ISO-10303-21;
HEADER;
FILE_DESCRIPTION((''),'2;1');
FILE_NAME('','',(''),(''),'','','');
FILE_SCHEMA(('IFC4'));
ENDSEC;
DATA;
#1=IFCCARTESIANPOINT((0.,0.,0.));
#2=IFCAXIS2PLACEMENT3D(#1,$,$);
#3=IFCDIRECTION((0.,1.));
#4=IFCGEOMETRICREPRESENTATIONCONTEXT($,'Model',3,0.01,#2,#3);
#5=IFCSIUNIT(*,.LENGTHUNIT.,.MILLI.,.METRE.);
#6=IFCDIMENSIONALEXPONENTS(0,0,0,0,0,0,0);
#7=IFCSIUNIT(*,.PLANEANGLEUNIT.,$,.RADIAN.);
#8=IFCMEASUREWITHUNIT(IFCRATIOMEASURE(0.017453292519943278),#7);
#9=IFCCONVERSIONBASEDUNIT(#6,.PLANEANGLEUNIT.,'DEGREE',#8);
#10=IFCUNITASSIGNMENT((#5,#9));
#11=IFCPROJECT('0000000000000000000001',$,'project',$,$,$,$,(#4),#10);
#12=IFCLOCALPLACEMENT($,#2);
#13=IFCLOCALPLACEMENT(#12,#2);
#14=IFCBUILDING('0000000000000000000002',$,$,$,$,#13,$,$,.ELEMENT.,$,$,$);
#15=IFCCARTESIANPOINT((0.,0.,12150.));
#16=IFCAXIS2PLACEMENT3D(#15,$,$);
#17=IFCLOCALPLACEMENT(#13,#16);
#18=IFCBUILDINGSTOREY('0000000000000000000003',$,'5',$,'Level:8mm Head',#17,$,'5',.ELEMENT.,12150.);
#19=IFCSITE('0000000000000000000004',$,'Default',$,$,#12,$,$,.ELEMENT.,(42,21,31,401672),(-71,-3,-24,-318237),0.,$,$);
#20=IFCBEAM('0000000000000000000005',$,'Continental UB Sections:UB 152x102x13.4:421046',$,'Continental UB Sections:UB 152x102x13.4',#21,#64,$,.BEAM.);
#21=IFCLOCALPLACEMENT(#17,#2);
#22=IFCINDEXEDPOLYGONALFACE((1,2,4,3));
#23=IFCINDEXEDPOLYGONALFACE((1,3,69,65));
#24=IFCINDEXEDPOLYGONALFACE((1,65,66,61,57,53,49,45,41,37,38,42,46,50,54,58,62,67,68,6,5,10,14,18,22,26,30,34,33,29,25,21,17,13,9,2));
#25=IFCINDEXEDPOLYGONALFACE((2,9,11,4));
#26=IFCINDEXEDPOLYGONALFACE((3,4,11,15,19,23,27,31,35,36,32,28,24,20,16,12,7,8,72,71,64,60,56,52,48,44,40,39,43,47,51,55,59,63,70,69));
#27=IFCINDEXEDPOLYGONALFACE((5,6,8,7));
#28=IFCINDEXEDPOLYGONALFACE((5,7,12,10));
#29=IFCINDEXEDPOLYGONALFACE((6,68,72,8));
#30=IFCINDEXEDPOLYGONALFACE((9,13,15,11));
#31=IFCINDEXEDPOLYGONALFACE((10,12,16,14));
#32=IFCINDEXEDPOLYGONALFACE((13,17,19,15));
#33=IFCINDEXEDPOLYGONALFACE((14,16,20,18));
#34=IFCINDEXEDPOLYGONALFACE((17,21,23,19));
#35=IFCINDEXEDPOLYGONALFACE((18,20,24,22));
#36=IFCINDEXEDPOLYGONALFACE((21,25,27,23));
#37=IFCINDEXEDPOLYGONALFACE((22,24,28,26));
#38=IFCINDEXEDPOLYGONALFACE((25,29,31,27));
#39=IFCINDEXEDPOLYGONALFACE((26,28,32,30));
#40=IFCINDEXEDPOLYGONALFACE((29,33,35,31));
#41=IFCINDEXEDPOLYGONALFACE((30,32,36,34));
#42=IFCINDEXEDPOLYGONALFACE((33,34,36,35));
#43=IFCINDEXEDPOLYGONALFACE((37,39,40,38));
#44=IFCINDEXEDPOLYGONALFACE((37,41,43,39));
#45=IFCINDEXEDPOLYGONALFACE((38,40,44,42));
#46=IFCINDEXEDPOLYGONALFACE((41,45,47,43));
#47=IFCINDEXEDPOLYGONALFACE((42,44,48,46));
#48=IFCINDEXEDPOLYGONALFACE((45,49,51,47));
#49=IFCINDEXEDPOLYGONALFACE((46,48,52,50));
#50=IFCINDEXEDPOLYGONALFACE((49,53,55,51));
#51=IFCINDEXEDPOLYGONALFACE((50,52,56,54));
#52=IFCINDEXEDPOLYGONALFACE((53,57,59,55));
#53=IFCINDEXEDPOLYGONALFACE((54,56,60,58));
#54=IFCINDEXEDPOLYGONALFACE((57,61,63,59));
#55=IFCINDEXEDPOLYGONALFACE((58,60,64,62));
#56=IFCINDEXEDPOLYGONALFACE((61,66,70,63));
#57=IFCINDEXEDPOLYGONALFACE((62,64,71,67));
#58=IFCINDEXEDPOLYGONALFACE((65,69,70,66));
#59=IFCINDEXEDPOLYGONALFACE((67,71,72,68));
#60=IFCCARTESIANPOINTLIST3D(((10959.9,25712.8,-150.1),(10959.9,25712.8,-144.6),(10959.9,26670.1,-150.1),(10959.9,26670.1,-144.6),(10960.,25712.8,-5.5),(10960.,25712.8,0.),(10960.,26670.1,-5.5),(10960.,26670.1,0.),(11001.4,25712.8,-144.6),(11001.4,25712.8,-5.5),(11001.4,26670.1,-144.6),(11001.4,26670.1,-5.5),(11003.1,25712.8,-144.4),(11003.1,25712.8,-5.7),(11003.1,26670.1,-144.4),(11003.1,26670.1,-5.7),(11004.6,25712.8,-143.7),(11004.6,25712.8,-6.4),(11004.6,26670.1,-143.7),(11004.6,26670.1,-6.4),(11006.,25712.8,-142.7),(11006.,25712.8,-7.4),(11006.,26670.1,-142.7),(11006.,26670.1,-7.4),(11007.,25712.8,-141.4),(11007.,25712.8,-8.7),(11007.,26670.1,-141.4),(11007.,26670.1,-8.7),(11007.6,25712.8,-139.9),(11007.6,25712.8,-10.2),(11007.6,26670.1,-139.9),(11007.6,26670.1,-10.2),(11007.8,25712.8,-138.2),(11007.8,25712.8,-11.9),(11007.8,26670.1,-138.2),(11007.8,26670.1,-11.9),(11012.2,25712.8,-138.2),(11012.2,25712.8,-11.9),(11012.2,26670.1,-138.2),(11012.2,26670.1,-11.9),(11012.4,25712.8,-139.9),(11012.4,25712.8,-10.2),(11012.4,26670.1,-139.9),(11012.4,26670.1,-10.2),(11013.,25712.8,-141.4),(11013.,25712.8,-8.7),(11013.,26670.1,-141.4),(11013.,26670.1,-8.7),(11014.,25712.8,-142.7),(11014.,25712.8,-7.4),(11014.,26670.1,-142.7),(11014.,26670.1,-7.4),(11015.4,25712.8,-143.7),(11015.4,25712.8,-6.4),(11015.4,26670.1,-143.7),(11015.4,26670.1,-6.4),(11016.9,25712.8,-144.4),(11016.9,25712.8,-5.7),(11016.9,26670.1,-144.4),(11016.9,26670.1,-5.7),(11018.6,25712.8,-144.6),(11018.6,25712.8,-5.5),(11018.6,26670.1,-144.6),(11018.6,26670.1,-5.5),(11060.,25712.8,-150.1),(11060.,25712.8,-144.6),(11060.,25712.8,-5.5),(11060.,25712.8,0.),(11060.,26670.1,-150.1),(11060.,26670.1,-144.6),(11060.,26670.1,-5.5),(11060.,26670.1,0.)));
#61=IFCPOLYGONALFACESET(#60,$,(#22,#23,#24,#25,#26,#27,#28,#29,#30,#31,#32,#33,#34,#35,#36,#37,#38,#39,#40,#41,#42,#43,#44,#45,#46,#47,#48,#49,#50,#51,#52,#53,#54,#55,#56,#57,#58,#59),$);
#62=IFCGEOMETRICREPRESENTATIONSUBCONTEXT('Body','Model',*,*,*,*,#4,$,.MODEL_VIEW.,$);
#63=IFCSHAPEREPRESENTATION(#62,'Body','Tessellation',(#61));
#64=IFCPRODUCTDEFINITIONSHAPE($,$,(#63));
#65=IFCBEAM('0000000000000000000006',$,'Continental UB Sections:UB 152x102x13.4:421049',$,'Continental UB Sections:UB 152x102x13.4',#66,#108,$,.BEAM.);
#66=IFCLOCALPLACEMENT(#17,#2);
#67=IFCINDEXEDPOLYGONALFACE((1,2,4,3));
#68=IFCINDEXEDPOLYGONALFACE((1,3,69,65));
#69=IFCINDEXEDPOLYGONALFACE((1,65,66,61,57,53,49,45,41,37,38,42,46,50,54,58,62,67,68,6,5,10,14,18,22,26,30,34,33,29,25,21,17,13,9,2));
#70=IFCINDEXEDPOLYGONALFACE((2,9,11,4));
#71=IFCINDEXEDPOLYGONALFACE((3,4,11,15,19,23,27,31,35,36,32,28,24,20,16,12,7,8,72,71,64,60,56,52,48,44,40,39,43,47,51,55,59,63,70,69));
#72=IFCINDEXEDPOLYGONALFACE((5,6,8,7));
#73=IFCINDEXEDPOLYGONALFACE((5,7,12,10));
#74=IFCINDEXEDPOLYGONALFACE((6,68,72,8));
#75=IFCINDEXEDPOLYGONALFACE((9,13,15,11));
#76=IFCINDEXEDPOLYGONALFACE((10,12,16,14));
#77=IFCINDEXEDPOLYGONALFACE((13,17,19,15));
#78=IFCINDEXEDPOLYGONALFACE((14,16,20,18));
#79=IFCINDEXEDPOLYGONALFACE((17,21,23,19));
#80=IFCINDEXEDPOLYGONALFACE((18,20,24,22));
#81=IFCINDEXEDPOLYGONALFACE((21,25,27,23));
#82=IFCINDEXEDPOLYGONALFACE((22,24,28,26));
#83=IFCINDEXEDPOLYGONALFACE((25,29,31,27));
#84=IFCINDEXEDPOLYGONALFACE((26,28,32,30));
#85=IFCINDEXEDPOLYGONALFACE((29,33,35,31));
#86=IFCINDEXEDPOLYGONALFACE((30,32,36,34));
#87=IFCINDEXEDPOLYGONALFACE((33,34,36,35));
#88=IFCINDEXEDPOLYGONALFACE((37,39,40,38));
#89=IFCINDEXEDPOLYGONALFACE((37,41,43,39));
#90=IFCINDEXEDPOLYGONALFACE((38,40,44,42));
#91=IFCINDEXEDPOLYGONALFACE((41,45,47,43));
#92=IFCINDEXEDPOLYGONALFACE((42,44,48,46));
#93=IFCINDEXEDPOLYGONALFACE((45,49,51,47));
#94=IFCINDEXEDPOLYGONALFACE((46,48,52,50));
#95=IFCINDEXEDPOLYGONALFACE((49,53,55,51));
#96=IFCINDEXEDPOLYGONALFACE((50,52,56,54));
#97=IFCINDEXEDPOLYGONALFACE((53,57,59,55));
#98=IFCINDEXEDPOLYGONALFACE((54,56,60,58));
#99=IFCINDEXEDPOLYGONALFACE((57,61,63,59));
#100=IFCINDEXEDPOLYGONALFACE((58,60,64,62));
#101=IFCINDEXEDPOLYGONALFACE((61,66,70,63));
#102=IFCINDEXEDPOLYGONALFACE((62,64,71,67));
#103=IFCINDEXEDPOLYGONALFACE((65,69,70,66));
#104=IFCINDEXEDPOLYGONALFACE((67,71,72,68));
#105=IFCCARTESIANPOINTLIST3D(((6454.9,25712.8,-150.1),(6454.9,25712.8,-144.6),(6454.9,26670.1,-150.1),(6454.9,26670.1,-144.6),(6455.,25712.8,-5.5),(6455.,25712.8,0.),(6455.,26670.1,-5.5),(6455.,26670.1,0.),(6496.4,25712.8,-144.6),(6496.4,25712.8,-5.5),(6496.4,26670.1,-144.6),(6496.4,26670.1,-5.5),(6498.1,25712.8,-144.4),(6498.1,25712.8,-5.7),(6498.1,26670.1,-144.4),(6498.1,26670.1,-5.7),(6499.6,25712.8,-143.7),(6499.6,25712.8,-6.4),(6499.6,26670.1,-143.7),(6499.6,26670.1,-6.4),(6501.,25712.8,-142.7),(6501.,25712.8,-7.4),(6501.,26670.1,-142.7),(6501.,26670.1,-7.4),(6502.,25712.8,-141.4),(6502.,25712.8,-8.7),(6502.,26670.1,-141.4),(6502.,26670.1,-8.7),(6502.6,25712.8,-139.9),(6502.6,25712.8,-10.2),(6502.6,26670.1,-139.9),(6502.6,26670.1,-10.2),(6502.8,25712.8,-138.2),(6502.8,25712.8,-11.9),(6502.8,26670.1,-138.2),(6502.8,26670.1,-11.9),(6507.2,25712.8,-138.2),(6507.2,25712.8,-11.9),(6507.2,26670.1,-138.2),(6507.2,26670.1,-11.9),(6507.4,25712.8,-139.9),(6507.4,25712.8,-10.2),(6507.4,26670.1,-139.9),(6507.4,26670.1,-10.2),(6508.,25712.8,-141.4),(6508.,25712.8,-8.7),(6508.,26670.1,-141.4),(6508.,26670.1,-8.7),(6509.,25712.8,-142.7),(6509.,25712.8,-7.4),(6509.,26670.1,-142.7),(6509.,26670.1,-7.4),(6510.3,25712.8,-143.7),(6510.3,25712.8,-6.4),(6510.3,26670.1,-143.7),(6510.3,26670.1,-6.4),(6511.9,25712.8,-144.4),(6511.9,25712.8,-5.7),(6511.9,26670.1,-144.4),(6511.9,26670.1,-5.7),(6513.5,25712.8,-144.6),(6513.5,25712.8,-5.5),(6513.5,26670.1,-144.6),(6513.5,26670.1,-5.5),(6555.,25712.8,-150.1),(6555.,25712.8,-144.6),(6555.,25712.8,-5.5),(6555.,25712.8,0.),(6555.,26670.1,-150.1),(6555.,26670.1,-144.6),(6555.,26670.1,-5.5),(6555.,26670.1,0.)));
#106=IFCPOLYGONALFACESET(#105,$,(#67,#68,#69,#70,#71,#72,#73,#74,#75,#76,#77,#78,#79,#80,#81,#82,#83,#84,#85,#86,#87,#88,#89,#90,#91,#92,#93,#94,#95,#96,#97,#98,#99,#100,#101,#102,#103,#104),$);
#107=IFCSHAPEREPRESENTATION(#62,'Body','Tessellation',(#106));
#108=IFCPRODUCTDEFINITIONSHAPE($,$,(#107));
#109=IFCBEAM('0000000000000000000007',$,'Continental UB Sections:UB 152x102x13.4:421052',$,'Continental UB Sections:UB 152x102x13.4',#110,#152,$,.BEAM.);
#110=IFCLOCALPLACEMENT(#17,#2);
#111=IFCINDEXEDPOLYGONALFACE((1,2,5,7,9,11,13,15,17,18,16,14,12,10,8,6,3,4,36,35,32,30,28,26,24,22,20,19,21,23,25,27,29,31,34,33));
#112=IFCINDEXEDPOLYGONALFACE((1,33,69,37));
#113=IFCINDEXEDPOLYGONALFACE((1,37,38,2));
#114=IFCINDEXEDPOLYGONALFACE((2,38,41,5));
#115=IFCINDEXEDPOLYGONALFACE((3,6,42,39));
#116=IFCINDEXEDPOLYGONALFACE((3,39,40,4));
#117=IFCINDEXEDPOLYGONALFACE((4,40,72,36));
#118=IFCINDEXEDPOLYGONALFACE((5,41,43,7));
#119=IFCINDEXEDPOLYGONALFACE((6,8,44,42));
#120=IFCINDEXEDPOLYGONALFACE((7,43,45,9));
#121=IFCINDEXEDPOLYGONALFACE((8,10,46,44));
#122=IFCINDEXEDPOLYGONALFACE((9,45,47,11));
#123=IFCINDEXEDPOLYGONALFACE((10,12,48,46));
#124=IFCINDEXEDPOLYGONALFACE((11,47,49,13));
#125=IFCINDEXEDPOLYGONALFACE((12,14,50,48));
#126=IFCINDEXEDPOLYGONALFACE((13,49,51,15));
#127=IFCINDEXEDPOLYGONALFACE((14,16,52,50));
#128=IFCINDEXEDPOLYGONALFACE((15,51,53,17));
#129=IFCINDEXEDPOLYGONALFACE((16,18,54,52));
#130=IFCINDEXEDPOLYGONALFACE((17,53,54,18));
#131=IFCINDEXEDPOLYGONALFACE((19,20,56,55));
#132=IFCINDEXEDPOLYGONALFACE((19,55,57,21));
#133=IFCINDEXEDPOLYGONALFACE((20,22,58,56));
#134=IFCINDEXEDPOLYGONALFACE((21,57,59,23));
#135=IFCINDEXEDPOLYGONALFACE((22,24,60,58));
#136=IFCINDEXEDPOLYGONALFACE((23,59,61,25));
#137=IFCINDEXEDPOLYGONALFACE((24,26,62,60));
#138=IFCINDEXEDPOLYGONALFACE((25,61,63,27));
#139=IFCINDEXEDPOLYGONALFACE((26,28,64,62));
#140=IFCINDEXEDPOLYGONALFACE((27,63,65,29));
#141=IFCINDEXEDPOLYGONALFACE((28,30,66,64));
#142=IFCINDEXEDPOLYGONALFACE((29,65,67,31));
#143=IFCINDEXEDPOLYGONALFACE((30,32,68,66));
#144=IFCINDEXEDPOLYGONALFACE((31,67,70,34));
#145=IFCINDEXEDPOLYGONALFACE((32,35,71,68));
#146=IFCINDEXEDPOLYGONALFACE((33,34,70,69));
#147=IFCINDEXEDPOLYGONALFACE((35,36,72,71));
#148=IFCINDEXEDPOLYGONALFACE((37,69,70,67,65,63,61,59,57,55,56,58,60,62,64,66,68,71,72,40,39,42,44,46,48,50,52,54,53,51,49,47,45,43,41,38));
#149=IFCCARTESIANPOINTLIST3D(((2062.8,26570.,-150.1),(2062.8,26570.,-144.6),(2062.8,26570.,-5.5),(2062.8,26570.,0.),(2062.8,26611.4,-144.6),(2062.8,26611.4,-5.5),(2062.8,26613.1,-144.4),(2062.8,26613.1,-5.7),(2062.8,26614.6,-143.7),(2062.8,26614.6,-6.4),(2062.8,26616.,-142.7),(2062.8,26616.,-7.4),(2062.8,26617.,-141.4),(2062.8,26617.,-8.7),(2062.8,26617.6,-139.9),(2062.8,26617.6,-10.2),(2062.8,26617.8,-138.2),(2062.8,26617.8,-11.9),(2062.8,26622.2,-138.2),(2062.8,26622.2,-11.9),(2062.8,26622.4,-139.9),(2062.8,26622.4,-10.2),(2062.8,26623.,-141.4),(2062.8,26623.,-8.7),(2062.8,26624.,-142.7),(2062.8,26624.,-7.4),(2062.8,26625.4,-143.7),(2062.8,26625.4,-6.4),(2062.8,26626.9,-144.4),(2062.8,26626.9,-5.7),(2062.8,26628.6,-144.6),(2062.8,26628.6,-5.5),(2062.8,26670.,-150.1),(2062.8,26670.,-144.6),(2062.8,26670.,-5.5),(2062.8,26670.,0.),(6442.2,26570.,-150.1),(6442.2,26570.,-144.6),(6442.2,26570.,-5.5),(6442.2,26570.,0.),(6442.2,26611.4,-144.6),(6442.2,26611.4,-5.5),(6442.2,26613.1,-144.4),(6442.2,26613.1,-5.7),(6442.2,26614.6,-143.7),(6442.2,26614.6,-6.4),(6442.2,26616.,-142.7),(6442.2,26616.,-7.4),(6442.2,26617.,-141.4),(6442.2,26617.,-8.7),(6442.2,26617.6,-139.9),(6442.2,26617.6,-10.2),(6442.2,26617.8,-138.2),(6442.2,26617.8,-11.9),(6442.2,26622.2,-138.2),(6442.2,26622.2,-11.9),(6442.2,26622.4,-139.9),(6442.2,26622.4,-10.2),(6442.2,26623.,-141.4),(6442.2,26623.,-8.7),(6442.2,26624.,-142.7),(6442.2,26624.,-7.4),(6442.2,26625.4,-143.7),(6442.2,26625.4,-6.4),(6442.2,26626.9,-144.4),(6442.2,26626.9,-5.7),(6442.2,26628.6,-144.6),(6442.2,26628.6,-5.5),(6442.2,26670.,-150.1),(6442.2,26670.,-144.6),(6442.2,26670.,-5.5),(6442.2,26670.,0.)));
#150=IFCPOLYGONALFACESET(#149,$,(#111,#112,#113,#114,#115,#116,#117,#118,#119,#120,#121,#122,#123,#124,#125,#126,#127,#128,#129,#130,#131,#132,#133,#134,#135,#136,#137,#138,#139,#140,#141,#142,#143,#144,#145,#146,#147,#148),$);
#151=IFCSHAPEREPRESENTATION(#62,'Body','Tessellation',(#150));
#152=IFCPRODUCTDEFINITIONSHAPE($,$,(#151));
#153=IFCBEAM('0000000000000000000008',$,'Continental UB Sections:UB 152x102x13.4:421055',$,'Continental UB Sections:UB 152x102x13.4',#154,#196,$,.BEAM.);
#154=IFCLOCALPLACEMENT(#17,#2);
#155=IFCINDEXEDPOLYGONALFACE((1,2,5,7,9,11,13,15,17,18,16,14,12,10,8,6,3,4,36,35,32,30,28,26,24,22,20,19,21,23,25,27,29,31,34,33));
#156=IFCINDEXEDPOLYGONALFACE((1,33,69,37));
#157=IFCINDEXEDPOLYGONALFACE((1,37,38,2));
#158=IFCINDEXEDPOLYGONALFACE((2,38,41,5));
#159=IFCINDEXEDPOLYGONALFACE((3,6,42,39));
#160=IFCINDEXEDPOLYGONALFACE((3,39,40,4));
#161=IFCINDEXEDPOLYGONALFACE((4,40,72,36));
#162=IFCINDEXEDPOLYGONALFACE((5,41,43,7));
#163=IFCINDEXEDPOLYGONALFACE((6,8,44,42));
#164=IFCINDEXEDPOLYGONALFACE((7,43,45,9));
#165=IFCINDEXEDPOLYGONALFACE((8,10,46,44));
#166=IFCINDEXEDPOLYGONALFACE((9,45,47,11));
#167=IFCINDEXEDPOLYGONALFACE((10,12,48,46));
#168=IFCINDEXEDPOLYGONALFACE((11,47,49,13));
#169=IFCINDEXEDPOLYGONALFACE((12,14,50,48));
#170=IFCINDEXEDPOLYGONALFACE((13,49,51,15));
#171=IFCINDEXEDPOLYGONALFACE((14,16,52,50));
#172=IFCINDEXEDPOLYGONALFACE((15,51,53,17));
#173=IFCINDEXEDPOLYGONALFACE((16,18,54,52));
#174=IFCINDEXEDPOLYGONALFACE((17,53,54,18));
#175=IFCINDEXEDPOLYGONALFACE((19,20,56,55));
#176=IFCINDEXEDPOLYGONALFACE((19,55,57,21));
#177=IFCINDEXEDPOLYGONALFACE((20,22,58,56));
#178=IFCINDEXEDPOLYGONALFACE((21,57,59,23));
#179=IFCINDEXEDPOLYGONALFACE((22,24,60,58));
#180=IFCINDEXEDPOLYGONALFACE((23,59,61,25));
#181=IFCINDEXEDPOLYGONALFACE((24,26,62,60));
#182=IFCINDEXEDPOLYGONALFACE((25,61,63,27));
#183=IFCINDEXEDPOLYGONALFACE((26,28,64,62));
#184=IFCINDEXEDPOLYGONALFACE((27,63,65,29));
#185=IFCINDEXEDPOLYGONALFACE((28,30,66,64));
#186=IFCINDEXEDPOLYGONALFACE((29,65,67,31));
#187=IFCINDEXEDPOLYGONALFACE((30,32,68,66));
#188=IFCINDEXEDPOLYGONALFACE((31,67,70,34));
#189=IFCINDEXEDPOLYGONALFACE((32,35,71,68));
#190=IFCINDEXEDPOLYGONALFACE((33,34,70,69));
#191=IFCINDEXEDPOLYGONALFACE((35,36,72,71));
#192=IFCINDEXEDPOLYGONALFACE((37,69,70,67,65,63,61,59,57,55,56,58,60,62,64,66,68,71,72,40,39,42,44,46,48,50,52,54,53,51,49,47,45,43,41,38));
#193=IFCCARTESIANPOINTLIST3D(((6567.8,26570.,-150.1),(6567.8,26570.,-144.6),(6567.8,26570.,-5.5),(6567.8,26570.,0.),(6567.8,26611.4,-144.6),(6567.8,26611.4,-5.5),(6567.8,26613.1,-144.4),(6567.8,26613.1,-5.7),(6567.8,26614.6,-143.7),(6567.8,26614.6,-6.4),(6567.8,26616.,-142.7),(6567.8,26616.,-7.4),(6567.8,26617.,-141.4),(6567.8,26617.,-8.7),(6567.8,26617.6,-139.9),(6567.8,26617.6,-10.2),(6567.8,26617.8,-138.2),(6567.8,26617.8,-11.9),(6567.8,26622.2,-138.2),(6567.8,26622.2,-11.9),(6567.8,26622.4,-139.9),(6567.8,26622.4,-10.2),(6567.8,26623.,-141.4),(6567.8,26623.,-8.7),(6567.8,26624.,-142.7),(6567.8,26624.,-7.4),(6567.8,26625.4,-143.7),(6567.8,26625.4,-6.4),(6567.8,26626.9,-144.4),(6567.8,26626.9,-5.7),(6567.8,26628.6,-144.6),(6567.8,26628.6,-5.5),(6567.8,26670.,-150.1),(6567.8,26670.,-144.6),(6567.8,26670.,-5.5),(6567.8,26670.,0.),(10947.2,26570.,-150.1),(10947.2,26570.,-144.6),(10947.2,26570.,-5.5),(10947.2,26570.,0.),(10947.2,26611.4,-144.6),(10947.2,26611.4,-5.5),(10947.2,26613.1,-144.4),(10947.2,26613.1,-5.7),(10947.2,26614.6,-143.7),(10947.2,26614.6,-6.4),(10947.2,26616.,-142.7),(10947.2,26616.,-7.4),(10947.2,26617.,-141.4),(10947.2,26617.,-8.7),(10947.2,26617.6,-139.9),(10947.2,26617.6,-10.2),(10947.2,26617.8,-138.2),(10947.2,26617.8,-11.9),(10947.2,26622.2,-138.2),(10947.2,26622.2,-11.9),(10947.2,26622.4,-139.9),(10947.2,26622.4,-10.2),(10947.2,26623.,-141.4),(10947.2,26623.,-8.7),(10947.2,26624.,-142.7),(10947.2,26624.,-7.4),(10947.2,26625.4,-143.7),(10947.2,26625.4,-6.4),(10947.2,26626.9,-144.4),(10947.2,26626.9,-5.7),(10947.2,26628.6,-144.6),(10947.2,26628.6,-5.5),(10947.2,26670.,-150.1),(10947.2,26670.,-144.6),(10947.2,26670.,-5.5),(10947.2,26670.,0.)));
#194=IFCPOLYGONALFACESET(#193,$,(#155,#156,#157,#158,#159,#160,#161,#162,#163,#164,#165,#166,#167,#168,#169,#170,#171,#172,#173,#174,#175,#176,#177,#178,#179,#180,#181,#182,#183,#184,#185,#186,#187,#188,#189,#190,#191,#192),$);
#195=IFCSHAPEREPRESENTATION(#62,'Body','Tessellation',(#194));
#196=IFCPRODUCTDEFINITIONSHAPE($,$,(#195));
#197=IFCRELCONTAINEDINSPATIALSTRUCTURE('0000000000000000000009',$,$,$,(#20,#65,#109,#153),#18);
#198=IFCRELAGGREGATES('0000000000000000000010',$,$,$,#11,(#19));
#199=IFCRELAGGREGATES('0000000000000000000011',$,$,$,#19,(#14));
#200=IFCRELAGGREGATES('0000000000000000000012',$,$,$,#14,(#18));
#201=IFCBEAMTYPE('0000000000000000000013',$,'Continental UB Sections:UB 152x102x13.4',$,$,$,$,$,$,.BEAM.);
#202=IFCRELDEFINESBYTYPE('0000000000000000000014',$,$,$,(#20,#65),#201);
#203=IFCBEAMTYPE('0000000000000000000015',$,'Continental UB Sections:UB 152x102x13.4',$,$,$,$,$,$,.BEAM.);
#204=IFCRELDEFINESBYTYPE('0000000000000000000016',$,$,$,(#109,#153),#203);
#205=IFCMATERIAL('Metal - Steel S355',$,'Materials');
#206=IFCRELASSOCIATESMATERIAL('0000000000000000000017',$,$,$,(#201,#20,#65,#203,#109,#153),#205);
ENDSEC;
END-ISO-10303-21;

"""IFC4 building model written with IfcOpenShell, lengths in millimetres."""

from ifc_helpers import new_model, entity, si_unit, converted_unit, direction, frame, origin, place, context, subcontext, project, spatial, line, arc, indexed_curve, outline, extrude, source, transform, mapped, material, type_object, type_shapes, element, save


model = new_model("IFC4")

# Units and contexts
model_context = context("Model", 3, precision=0.01, world=origin(), true_north=direction((0.0, 1.0)))
body_context = subcontext(model_context, "Body", "Model", "MODEL_VIEW")
ifc_project = project(units=[si_unit("LENGTHUNIT", "METRE", prefix="MILLI"), converted_unit("PLANEANGLEUNIT", "DEGREE", entity("IfcRatioMeasure", 0.017453292519943278), si_unit("PLANEANGLEUNIT", "RADIAN"), dimensions=[0, 0, 0, 0, 0, 0, 0])], contexts=[model_context])

# Site, building, storey
site_placement = place(None, origin())
site = spatial("IfcSite", under=ifc_project, at=site_placement, Name="Default", CompositionType="ELEMENT", RefLatitude=(42, 21, 31, 401672), RefLongitude=(-71, -3, -24, -318237), RefElevation=0.0)
building_placement = place(site_placement, origin())
building = spatial("IfcBuilding", under=site, at=building_placement, CompositionType="ELEMENT")
storey_placement = place(building_placement, frame((0.0, 0.0, 12150.0)))
storey = spatial("IfcBuildingStorey", under=building, at=storey_placement, Name="5", ObjectType="Level:8mm Head", LongName="5", CompositionType="ELEMENT", Elevation=12150.0)

# Beams
ifc_material = material(Name="Metal - Steel S355", Category="Materials")
beam_type_1 = type_object("IfcBeamType", Name="Continental UB Sections:UB 152x102x13.4", PredefinedType="BEAM", material=ifc_material)
shared_shape_1 = source(origin(), body_context, "Body", "SweptSolid", [
    extrude(outline(indexed_curve([(-75.0, -50.1), (-69.6, -50.1), (-69.6, -8.5), (-67.7, -4.0), (-63.2, -2.1), (63.1, -2.1), (67.7, -4.0), (69.5, -8.5), (69.5, -50.1), (75.1, -50.1), (75.1, 50.1), (69.5, 50.1), (69.5, 8.6), (67.7, 4.0), (63.1, 2.2), (-63.2, 2.2), (-67.7, 4.0), (-69.6, 8.6), (-69.6, 50.0), (-75.0, 50.0)], segments=[line(1, 2, 3), arc(3, 4, 5), line(5, 6), arc(6, 7, 8), line(8, 9, 10, 11, 12, 13), arc(13, 14, 15), line(15, 16), arc(16, 17, 18), line(18, 19, 20, 1)], self_intersect=False)), frame((-447.2, 0.0, 0.0), z_axis=(1.0, 0.0, 0.0), x_axis=(0.0, 0.0, -1.0)), (0.0, 0.0, 1.0), 957.3),
])
type_shapes(beam_type_1, [shared_shape_1])
for number, where, z_axis, x_axis, name in (
    (1, (11010.0, 26160.0, -75.1), (0.0, 0.0, 1.0), (0.0, 1.0, 0.0), "Continental UB Sections:UB 152x102x13.4:421046"),
    (2, (6505.0, 26160.0, -75.1), (0.0, 0.0, 1.0), (0.0, 1.0, 0.0), "Continental UB Sections:UB 152x102x13.4:421049"),
):
    element("IfcBeam", number, at=place(storey_placement, frame(where, z_axis=z_axis, x_axis=x_axis)), inside=storey, type_object=beam_type_1, material=ifc_material, Name=name, ObjectType="Continental UB Sections:UB 152x102x13.4", PredefinedType="BEAM", context=body_context, shape_type="MappedRepresentation", body=[
        mapped(shared_shape_1, transform((0.0, 0.0, 0.0), scale=1.0)),
    ])
beam_type_2 = type_object("IfcBeamType", Name="Continental UB Sections:UB 152x102x13.4", PredefinedType="BEAM", material=ifc_material)
shared_shape_2 = source(origin(), body_context, "Body", "SweptSolid", [
    extrude(outline(indexed_curve([(-75.0, -50.1), (-69.6, -50.1), (-69.6, -8.5), (-67.7, -4.0), (-63.2, -2.1), (63.1, -2.1), (67.7, -4.0), (69.5, -8.5), (69.5, -50.1), (75.1, -50.1), (75.1, 50.1), (69.5, 50.1), (69.5, 8.6), (67.7, 4.0), (63.1, 2.2), (-63.2, 2.2), (-67.7, 4.0), (-69.6, 8.6), (-69.6, 50.0), (-75.0, 50.0)], segments=[line(1, 2, 3), arc(3, 4, 5), line(5, 6), arc(6, 7, 8), line(8, 9, 10, 11, 12, 13), arc(13, 14, 15), line(15, 16), arc(16, 17, 18), line(18, 19, 20, 1)], self_intersect=False)), frame((-2189.7, 0.0, 0.0), z_axis=(1.0, 0.0, 0.0), x_axis=(0.0, 0.0, -1.0)), (0.0, 0.0, 1.0), 4379.4),
])
type_shapes(beam_type_2, [shared_shape_2])
for number, where, name in (
    (3, (4252.5, 26620.0, -75.1), "Continental UB Sections:UB 152x102x13.4:421052"),
    (4, (8757.5, 26620.0, -75.1), "Continental UB Sections:UB 152x102x13.4:421055"),
):
    element("IfcBeam", number, at=place(storey_placement, frame(where)), inside=storey, type_object=beam_type_2, material=ifc_material, Name=name, ObjectType="Continental UB Sections:UB 152x102x13.4", PredefinedType="BEAM", context=body_context, shape_type="MappedRepresentation", body=[
        mapped(shared_shape_2, transform((0.0, 0.0, 0.0), scale=1.0)),
    ])

save(model, "model.ifc")
